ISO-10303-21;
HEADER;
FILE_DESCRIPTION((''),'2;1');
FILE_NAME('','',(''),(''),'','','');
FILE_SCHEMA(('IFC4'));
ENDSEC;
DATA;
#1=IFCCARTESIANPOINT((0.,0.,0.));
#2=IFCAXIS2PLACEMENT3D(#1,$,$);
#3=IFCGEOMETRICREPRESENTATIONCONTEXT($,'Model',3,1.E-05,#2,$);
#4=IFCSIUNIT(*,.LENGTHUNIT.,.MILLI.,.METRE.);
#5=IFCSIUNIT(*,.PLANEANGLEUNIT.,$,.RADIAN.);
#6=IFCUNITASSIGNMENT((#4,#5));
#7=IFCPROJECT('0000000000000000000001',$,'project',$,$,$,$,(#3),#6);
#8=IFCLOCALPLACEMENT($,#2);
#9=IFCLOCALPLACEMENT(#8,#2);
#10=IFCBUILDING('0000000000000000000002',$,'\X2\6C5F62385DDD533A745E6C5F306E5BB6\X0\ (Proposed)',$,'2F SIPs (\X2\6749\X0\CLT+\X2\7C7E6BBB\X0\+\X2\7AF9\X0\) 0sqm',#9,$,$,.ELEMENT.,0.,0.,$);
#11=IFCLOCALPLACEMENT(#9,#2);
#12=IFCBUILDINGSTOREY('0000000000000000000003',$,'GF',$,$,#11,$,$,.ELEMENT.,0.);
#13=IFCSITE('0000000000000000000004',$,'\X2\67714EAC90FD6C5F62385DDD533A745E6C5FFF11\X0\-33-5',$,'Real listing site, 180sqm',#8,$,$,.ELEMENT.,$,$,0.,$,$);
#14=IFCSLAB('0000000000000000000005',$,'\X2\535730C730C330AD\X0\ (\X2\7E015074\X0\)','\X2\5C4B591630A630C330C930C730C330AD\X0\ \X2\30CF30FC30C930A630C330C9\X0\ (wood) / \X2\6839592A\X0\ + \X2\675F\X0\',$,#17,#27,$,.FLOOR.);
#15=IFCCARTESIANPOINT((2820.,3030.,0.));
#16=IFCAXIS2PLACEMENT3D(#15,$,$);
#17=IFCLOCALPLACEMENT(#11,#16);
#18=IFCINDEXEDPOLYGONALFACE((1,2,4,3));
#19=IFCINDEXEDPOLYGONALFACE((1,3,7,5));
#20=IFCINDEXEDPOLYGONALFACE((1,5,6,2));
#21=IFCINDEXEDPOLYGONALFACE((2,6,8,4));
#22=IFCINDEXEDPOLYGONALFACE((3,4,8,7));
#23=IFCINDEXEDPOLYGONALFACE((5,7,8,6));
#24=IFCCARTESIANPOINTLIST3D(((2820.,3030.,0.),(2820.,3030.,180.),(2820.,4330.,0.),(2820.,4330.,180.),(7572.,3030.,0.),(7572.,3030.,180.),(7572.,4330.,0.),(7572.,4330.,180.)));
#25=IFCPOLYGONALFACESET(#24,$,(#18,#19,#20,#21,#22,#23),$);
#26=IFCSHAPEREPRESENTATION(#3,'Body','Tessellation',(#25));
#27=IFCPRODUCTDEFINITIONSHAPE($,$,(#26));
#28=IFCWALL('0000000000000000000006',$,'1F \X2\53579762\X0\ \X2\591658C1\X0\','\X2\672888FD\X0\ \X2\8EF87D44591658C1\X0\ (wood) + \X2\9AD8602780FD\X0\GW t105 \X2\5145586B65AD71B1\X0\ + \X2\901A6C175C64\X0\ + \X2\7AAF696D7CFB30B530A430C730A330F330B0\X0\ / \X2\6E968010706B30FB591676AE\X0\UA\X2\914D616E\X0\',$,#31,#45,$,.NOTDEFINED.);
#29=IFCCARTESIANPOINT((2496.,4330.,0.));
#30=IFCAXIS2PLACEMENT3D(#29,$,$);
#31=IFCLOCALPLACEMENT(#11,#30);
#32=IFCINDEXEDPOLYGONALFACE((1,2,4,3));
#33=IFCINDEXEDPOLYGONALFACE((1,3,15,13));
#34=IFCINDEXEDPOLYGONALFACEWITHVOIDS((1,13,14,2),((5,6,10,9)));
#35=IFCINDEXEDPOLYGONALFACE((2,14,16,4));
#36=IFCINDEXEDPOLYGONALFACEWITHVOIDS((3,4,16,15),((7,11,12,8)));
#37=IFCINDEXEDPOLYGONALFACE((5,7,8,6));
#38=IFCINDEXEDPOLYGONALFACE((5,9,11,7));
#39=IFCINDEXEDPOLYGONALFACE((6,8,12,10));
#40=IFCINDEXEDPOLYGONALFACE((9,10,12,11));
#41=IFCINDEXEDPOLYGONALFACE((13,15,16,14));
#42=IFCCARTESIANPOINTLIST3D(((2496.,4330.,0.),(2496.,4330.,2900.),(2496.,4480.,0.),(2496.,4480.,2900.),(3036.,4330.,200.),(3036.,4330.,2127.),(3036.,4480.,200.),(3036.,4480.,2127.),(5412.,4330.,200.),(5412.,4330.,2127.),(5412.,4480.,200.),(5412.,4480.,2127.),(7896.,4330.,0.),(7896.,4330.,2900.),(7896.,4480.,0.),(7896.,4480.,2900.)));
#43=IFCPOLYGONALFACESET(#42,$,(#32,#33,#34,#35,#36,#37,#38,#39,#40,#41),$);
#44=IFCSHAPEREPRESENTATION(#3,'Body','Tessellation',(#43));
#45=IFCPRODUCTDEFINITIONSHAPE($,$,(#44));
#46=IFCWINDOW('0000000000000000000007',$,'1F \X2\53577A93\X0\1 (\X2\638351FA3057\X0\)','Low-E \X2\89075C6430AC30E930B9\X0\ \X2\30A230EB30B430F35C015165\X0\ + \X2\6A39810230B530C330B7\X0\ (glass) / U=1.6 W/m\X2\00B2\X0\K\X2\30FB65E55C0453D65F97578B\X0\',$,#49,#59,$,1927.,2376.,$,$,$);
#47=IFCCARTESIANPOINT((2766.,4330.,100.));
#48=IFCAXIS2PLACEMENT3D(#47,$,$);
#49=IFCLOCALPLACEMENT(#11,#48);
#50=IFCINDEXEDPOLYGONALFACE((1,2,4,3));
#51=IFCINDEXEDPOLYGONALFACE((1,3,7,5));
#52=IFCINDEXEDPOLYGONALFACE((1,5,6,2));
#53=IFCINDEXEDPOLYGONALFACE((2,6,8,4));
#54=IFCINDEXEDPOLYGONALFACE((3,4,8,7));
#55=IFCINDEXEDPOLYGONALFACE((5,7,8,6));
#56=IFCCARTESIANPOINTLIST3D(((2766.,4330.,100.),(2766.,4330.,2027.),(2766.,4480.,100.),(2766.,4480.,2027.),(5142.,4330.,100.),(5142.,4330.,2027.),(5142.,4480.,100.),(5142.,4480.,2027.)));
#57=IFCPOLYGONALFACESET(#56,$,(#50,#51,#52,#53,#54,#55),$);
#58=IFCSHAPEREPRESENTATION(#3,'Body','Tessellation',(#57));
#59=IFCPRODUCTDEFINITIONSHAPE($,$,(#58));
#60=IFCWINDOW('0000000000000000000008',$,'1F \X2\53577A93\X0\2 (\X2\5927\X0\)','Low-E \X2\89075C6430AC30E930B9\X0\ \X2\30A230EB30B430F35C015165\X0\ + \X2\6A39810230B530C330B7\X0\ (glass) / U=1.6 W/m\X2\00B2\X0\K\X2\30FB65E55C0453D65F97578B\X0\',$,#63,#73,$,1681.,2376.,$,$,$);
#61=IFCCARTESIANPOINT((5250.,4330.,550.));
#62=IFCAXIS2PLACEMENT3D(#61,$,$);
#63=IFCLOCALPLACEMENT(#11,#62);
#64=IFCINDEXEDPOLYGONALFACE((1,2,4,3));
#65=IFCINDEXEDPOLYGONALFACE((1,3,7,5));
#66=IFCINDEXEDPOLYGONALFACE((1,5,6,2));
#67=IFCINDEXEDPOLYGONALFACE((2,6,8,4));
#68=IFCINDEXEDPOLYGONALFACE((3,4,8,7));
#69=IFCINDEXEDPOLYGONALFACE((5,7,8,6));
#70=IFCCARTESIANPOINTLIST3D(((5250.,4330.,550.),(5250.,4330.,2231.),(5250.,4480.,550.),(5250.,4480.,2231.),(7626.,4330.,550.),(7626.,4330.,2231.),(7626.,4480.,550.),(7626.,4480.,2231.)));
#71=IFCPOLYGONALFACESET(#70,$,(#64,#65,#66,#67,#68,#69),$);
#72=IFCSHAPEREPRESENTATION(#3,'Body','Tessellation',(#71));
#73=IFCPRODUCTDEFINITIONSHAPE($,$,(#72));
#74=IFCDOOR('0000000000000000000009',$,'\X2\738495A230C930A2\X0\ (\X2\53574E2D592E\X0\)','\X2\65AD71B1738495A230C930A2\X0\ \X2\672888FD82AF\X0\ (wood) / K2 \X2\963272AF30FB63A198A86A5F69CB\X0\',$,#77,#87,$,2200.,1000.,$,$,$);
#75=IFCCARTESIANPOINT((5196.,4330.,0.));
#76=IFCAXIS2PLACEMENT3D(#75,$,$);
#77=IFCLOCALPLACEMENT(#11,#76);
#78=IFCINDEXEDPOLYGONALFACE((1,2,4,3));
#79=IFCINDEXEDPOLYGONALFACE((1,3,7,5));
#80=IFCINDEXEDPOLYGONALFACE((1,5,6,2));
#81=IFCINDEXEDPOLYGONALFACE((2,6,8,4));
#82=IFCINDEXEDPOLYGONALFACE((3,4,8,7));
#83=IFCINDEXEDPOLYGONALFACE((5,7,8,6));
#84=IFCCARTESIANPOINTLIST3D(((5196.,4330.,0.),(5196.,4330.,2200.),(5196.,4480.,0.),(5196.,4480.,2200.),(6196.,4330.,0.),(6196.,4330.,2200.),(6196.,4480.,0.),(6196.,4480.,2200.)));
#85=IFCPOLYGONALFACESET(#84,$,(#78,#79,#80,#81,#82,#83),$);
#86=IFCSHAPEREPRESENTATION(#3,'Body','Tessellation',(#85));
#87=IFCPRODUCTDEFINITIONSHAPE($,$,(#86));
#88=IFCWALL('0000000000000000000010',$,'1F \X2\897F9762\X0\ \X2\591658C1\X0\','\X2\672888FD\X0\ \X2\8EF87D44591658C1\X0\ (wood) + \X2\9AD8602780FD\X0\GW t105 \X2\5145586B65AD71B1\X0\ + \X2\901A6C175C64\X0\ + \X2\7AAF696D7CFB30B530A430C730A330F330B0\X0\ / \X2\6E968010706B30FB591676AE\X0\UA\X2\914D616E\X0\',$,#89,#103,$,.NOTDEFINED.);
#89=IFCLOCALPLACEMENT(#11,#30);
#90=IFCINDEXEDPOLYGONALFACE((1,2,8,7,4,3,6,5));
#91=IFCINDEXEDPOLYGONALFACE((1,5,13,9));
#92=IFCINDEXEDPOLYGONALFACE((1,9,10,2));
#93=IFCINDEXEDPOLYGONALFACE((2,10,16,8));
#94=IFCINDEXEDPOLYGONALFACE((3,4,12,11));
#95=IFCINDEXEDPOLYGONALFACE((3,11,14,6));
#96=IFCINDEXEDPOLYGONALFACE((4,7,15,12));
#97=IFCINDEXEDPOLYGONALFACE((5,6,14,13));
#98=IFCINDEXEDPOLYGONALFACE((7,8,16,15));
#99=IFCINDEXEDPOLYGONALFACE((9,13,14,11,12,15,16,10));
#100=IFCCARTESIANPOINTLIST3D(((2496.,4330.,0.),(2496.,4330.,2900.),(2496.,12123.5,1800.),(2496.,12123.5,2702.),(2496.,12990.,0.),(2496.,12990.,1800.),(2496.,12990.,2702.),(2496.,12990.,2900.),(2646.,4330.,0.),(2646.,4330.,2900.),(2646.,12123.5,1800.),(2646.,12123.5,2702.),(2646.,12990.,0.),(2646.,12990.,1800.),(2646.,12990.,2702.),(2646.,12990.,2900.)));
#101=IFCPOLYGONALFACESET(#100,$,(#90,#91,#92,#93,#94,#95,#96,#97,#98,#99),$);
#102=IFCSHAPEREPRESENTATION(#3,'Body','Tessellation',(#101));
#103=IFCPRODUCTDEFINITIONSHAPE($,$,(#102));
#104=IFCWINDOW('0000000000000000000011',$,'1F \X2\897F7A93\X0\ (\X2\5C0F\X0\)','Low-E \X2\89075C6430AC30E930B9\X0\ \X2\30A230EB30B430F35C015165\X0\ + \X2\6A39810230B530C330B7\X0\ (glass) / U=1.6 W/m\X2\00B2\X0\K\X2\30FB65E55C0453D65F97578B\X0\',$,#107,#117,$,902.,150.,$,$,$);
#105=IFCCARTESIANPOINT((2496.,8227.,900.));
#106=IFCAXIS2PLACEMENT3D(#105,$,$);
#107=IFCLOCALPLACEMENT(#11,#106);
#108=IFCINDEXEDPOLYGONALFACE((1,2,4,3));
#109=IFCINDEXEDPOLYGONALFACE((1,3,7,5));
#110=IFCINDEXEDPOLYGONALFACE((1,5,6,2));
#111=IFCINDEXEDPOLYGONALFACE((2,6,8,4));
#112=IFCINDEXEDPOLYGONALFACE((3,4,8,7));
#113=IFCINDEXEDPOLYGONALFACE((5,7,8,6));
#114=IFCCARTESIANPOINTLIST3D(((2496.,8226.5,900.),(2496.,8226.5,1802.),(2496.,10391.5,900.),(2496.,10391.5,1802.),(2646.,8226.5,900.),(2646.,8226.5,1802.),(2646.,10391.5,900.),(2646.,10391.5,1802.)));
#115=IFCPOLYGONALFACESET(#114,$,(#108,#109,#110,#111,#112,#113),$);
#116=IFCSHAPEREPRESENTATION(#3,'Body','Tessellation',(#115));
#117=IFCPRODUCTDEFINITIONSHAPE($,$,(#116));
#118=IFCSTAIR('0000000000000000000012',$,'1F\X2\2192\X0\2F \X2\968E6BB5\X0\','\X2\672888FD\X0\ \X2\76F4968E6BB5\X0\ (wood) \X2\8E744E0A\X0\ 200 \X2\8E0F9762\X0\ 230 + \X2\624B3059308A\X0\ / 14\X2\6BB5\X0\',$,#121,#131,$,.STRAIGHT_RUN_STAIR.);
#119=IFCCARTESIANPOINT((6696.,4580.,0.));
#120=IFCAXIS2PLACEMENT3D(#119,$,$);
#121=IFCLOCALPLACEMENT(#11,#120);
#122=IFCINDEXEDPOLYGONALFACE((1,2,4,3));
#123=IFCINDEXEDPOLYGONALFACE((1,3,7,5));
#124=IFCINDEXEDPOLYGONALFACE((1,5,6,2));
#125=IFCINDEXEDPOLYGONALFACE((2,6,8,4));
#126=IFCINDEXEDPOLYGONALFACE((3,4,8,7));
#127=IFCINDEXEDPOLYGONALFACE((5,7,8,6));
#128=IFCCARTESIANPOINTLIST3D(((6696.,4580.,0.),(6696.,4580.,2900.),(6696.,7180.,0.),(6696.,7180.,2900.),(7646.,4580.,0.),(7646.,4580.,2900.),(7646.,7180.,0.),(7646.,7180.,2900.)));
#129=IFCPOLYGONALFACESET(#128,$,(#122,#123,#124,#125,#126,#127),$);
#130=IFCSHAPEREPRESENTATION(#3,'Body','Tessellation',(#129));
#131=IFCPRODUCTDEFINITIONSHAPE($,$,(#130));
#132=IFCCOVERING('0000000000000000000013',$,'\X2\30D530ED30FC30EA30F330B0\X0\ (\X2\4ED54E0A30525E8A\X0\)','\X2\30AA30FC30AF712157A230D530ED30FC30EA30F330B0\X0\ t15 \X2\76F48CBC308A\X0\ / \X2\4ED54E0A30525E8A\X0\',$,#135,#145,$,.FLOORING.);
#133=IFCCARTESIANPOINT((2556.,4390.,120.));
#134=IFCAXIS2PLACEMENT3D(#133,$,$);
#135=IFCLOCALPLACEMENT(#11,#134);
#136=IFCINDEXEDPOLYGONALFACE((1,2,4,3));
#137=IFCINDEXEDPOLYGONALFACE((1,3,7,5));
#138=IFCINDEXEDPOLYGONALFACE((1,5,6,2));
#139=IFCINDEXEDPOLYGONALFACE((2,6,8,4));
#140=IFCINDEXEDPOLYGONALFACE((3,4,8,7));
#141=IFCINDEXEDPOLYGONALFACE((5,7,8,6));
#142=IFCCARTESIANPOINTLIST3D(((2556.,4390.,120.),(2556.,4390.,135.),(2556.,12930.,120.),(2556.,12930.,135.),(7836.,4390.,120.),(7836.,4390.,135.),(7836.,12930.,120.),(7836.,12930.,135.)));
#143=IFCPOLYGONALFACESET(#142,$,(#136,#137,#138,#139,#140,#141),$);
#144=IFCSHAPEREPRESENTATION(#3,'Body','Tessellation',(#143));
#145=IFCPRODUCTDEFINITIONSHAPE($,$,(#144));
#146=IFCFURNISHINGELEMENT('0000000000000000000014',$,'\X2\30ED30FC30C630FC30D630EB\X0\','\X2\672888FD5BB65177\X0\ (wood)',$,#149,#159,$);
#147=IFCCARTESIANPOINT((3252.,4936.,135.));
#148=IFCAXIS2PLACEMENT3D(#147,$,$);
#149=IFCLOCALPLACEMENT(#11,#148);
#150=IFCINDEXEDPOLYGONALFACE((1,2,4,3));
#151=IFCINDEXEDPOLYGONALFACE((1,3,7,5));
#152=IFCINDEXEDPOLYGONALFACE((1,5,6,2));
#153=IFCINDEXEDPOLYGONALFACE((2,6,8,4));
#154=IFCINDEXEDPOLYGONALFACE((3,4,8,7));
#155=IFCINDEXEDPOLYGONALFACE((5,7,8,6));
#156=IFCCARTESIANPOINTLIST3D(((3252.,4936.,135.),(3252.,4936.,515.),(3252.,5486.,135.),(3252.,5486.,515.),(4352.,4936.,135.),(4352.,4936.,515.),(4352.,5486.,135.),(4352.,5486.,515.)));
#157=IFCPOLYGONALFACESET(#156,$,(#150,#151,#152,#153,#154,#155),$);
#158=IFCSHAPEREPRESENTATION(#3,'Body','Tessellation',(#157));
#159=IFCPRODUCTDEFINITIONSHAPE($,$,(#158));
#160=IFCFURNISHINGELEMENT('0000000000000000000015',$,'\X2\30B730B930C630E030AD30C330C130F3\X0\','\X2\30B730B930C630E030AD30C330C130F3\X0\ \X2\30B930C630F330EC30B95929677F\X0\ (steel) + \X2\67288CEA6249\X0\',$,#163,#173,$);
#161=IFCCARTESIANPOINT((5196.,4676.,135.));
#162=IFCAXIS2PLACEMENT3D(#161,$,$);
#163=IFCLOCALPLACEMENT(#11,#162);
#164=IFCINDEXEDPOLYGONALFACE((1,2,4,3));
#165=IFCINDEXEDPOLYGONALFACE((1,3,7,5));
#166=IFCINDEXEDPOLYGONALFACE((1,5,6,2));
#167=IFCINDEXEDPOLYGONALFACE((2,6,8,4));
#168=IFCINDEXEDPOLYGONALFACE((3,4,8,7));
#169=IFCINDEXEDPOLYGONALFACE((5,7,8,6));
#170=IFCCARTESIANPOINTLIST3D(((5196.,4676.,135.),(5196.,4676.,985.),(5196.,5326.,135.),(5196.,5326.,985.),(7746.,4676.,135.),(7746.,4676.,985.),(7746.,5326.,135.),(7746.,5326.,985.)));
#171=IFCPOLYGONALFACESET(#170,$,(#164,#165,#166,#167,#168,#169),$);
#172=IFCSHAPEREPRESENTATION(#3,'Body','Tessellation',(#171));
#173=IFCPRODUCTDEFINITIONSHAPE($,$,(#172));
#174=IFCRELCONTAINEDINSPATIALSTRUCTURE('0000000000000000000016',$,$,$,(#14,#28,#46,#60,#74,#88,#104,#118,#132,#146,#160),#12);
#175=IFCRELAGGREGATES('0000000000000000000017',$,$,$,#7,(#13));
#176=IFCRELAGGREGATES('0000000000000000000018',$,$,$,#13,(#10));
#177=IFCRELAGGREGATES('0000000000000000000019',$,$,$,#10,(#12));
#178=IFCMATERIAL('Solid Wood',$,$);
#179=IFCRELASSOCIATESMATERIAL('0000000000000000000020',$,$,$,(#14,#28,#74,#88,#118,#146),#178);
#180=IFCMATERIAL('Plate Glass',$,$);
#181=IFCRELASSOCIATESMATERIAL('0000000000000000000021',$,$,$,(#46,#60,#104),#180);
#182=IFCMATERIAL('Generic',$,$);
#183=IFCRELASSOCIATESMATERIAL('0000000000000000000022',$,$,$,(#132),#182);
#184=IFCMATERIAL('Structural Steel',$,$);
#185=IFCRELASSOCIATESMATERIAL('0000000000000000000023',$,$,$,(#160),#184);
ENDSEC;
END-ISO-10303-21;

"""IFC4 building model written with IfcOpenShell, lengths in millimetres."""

from ifc_helpers import new_model, si_unit, frame, frame_2d, origin, place, context, project, spatial, rectangle, extrude, material, element, fill, save


model = new_model("IFC4")

# Units and contexts
model_context = context("Model", 3, precision=1e-05, world=origin())
ifc_project = project(units=[si_unit("LENGTHUNIT", "METRE", prefix="MILLI"), si_unit("PLANEANGLEUNIT", "RADIAN")], contexts=[model_context])

# Site, building, storey
site_placement = place(None, origin())
site = spatial("IfcSite", under=ifc_project, at=site_placement, Name="東京都江戸川区瑞江１-33-5", ObjectType="Real listing site, 180sqm", CompositionType="ELEMENT", RefElevation=0.0)
building_placement = place(site_placement, origin())
building = spatial("IfcBuilding", under=site, at=building_placement, Name="江戸川区瑞江の家 (Proposed)", ObjectType="2F SIPs (杉CLT+籾殻+竹) 0sqm", CompositionType="ELEMENT", ElevationOfRefHeight=0.0, ElevationOfTerrain=0.0)
storey_placement = place(building_placement, origin())
storey = spatial("IfcBuildingStorey", under=building, at=storey_placement, Name="GF", CompositionType="ELEMENT", Elevation=0.0)

# Slab
ifc_material_1 = material(Name="Solid Wood")
slab_1_placement = place(storey_placement, frame((2820.0, 3030.0, 0.0)))
element("IfcSlab", 1, at=slab_1_placement, inside=storey, material=ifc_material_1, Name="南デッキ (縁側)", Description="屋外ウッドデッキ ハードウッド (wood) / 根太 + 束", PredefinedType="FLOOR", context=model_context, shape_type="SweptSolid", body=[
    extrude(rectangle(XDim=4752.0, YDim=1300.0, at=frame_2d((2376.0, 650.0))), frame((2820.0, 3030.0, 0.0)), (0.0, 0.0, 1.0), 180.0),
])

# Wall, openings, windows, door
wall_1_placement = place(storey_placement, frame((2496.0, 4330.0, 0.0)))
wall_1 = element("IfcWall", 2, at=wall_1_placement, inside=storey, material=ifc_material_1, Name="1F 南面 外壁", Description="木製 軸組外壁 (wood) + 高性能GW t105 充填断熱 + 通気層 + 窯業系サイディング / 準耐火・外皮UA配慮", PredefinedType="NOTDEFINED", context=model_context, shape_type="SweptSolid", body=[
    extrude(rectangle(XDim=5400.0, YDim=150.0, at=frame_2d((2700.0, 75.0))), frame((2496.0, 4330.0, 0.0)), (0.0, 0.0, 1.0), 2900.0),
])
opening_1_placement = place(storey_placement, frame((2766.0, 4330.0, 100.0)))
opening_1 = element("IfcOpeningElement", 3, at=opening_1_placement, cuts=wall_1, PredefinedType="NOTDEFINED", context=model_context, shape_type="SweptSolid", body=[
    extrude(rectangle(XDim=2376.0, YDim=150.0, at=frame_2d((1188.0, 75.0))), frame((2766.0, 4330.0, 100.0)), (0.0, 0.0, 1.0), 1927.0),
])
opening_2_placement = place(storey_placement, frame((5250.0, 4330.0, 550.0)))
opening_2 = element("IfcOpeningElement", 4, at=opening_2_placement, cuts=wall_1, PredefinedType="NOTDEFINED", context=model_context, shape_type="SweptSolid", body=[
    extrude(rectangle(XDim=2376.0, YDim=150.0, at=frame_2d((1188.0, 75.0))), frame((5250.0, 4330.0, 550.0)), (0.0, 0.0, 1.0), 1681.0),
])
opening_3_placement = place(storey_placement, frame((5196.0, 4330.0, 0.0)))
opening_3 = element("IfcOpeningElement", 5, at=opening_3_placement, cuts=wall_1, PredefinedType="NOTDEFINED", context=model_context, shape_type="SweptSolid", body=[
    extrude(rectangle(XDim=1000.0, YDim=150.0, at=frame_2d((500.0, 75.0))), frame((5196.0, 4330.0, 0.0)), (0.0, 0.0, 1.0), 2200.0),
])
ifc_material_2 = material(Name="Plate Glass")
window_1_placement = place(storey_placement, frame((2766.0, 4330.0, 100.0)))
window_1 = element("IfcWindow", 6, at=window_1_placement, inside=storey, material=ifc_material_2, Name="1F 南窓1 (掃出し)", Description="Low-E 複層ガラス アルゴン封入 + 樹脂サッシ (glass) / U=1.6 W/m²K・日射取得型", OverallHeight=1927.0, OverallWidth=2376.0, context=model_context, shape_type="SweptSolid", body=[
    extrude(rectangle(XDim=2376.0, YDim=150.0, at=frame_2d((1188.0, 75.0))), frame((2766.0, 4330.0, 100.0)), (0.0, 0.0, 1.0), 1927.0),
])
fill(opening_1, window_1)
window_2_placement = place(storey_placement, frame((5250.0, 4330.0, 550.0)))
window_2 = element("IfcWindow", 7, at=window_2_placement, inside=storey, material=ifc_material_2, Name="1F 南窓2 (大)", Description="Low-E 複層ガラス アルゴン封入 + 樹脂サッシ (glass) / U=1.6 W/m²K・日射取得型", OverallHeight=1681.0, OverallWidth=2376.0, context=model_context, shape_type="SweptSolid", body=[
    extrude(rectangle(XDim=2376.0, YDim=150.0, at=frame_2d((1188.0, 75.0))), frame((5250.0, 4330.0, 550.0)), (0.0, 0.0, 1.0), 1681.0),
])
fill(opening_2, window_2)
door_placement = place(storey_placement, frame((5196.0, 4330.0, 0.0)))
door = element("IfcDoor", 8, at=door_placement, inside=storey, material=ifc_material_1, Name="玄関ドア (南中央)", Description="断熱玄関ドア 木製芯 (wood) / K2 防犯・採風機構", OverallHeight=2200.0, OverallWidth=1000.0, context=model_context, shape_type="SweptSolid", body=[
    extrude(rectangle(XDim=1000.0, YDim=150.0, at=frame_2d((500.0, 75.0))), frame((5196.0, 4330.0, 0.0)), (0.0, 0.0, 1.0), 2200.0),
])
fill(opening_3, door)

# Wall, opening, window
wall_2_placement = place(storey_placement, frame((2496.0, 4330.0, 0.0)))
wall_2 = element("IfcWall", 9, at=wall_2_placement, inside=storey, material=ifc_material_1, Name="1F 西面 外壁", Description="木製 軸組外壁 (wood) + 高性能GW t105 充填断熱 + 通気層 + 窯業系サイディング / 準耐火・外皮UA配慮", PredefinedType="NOTDEFINED", context=model_context, shape_type="SweptSolid", body=[
    extrude(rectangle(XDim=150.0, YDim=8660.0, at=frame_2d((75.0, 4330.0))), frame((2496.0, 4330.0, 0.0)), (0.0, 0.0, 1.0), 2900.0),
])
opening_4_placement = place(storey_placement, frame((2496.0, 8227.0, 900.0)))
opening_4 = element("IfcOpeningElement", 10, at=opening_4_placement, cuts=wall_2, PredefinedType="NOTDEFINED", context=model_context, shape_type="SweptSolid", body=[
    extrude(rectangle(XDim=150.0, YDim=2165.0, at=frame_2d((75.0, 1082.0))), frame((2496.0, 8227.0, 900.0)), (0.0, 0.0, 1.0), 902.0),
])
window_3_placement = place(storey_placement, frame((2496.0, 8227.0, 900.0)))
window_3 = element("IfcWindow", 11, at=window_3_placement, inside=storey, material=ifc_material_2, Name="1F 西窓 (小)", Description="Low-E 複層ガラス アルゴン封入 + 樹脂サッシ (glass) / U=1.6 W/m²K・日射取得型", OverallHeight=902.0, OverallWidth=150.0, context=model_context, shape_type="SweptSolid", body=[
    extrude(rectangle(XDim=150.0, YDim=2165.0, at=frame_2d((75.0, 1082.0))), frame((2496.0, 8227.0, 900.0)), (0.0, 0.0, 1.0), 902.0),
])
fill(opening_4, window_3)

# Stair
stair_placement = place(storey_placement, frame((6696.0, 4580.0, 0.0)))
element("IfcStair", 12, at=stair_placement, inside=storey, material=ifc_material_1, Name="1F→2F 階段", Description="木製 直階段 (wood) 蹴上 200 踏面 230 + 手すり / 14段", PredefinedType="STRAIGHT_RUN_STAIR", context=model_context, shape_type="SweptSolid", body=[
    extrude(rectangle(XDim=950.0, YDim=2600.0, at=frame_2d((475.0, 1300.0))), frame((6696.0, 4580.0, 0.0)), (0.0, 0.0, 1.0), 2900.0),
])

# Covering
ifc_material_3 = material(Name="Generic")
covering_placement = place(storey_placement, frame((2556.0, 4390.0, 120.0)))
element("IfcCovering", 13, at=covering_placement, inside=storey, material=ifc_material_3, Name="フローリング (仕上げ床)", Description="オーク無垢フローリング t15 直貼り / 仕上げ床", PredefinedType="FLOORING", context=model_context, shape_type="SweptSolid", body=[
    extrude(rectangle(XDim=5280.0, YDim=8540.0, at=frame_2d((2640.0, 4270.0))), frame((2556.0, 4390.0, 120.0)), (0.0, 0.0, 1.0), 15.0),
])

# Furnishing elements
furnishing_1_placement = place(storey_placement, frame((3252.0, 4936.0, 135.0)))
element("IfcFurnishingElement", 14, at=furnishing_1_placement, inside=storey, material=ifc_material_1, Name="ローテーブル", Description="木製家具 (wood)", context=model_context, shape_type="SweptSolid", body=[
    extrude(rectangle(XDim=1100.0, YDim=550.0, at=frame_2d((550.0, 275.0))), frame((3252.0, 4936.0, 135.0)), (0.0, 0.0, 1.0), 380.0),
])
ifc_material_4 = material(Name="Structural Steel")
furnishing_2_placement = place(storey_placement, frame((5196.0, 4676.0, 135.0)))
element("IfcFurnishingElement", 15, at=furnishing_2_placement, inside=storey, material=ifc_material_4, Name="システムキッチン", Description="システムキッチン ステンレス天板 (steel) + 木質扉", context=model_context, shape_type="SweptSolid", body=[
    extrude(rectangle(XDim=2550.0, YDim=650.0, at=frame_2d((1275.0, 325.0))), frame((5196.0, 4676.0, 135.0)), (0.0, 0.0, 1.0), 850.0),
])

save(model, "model.ifc")
